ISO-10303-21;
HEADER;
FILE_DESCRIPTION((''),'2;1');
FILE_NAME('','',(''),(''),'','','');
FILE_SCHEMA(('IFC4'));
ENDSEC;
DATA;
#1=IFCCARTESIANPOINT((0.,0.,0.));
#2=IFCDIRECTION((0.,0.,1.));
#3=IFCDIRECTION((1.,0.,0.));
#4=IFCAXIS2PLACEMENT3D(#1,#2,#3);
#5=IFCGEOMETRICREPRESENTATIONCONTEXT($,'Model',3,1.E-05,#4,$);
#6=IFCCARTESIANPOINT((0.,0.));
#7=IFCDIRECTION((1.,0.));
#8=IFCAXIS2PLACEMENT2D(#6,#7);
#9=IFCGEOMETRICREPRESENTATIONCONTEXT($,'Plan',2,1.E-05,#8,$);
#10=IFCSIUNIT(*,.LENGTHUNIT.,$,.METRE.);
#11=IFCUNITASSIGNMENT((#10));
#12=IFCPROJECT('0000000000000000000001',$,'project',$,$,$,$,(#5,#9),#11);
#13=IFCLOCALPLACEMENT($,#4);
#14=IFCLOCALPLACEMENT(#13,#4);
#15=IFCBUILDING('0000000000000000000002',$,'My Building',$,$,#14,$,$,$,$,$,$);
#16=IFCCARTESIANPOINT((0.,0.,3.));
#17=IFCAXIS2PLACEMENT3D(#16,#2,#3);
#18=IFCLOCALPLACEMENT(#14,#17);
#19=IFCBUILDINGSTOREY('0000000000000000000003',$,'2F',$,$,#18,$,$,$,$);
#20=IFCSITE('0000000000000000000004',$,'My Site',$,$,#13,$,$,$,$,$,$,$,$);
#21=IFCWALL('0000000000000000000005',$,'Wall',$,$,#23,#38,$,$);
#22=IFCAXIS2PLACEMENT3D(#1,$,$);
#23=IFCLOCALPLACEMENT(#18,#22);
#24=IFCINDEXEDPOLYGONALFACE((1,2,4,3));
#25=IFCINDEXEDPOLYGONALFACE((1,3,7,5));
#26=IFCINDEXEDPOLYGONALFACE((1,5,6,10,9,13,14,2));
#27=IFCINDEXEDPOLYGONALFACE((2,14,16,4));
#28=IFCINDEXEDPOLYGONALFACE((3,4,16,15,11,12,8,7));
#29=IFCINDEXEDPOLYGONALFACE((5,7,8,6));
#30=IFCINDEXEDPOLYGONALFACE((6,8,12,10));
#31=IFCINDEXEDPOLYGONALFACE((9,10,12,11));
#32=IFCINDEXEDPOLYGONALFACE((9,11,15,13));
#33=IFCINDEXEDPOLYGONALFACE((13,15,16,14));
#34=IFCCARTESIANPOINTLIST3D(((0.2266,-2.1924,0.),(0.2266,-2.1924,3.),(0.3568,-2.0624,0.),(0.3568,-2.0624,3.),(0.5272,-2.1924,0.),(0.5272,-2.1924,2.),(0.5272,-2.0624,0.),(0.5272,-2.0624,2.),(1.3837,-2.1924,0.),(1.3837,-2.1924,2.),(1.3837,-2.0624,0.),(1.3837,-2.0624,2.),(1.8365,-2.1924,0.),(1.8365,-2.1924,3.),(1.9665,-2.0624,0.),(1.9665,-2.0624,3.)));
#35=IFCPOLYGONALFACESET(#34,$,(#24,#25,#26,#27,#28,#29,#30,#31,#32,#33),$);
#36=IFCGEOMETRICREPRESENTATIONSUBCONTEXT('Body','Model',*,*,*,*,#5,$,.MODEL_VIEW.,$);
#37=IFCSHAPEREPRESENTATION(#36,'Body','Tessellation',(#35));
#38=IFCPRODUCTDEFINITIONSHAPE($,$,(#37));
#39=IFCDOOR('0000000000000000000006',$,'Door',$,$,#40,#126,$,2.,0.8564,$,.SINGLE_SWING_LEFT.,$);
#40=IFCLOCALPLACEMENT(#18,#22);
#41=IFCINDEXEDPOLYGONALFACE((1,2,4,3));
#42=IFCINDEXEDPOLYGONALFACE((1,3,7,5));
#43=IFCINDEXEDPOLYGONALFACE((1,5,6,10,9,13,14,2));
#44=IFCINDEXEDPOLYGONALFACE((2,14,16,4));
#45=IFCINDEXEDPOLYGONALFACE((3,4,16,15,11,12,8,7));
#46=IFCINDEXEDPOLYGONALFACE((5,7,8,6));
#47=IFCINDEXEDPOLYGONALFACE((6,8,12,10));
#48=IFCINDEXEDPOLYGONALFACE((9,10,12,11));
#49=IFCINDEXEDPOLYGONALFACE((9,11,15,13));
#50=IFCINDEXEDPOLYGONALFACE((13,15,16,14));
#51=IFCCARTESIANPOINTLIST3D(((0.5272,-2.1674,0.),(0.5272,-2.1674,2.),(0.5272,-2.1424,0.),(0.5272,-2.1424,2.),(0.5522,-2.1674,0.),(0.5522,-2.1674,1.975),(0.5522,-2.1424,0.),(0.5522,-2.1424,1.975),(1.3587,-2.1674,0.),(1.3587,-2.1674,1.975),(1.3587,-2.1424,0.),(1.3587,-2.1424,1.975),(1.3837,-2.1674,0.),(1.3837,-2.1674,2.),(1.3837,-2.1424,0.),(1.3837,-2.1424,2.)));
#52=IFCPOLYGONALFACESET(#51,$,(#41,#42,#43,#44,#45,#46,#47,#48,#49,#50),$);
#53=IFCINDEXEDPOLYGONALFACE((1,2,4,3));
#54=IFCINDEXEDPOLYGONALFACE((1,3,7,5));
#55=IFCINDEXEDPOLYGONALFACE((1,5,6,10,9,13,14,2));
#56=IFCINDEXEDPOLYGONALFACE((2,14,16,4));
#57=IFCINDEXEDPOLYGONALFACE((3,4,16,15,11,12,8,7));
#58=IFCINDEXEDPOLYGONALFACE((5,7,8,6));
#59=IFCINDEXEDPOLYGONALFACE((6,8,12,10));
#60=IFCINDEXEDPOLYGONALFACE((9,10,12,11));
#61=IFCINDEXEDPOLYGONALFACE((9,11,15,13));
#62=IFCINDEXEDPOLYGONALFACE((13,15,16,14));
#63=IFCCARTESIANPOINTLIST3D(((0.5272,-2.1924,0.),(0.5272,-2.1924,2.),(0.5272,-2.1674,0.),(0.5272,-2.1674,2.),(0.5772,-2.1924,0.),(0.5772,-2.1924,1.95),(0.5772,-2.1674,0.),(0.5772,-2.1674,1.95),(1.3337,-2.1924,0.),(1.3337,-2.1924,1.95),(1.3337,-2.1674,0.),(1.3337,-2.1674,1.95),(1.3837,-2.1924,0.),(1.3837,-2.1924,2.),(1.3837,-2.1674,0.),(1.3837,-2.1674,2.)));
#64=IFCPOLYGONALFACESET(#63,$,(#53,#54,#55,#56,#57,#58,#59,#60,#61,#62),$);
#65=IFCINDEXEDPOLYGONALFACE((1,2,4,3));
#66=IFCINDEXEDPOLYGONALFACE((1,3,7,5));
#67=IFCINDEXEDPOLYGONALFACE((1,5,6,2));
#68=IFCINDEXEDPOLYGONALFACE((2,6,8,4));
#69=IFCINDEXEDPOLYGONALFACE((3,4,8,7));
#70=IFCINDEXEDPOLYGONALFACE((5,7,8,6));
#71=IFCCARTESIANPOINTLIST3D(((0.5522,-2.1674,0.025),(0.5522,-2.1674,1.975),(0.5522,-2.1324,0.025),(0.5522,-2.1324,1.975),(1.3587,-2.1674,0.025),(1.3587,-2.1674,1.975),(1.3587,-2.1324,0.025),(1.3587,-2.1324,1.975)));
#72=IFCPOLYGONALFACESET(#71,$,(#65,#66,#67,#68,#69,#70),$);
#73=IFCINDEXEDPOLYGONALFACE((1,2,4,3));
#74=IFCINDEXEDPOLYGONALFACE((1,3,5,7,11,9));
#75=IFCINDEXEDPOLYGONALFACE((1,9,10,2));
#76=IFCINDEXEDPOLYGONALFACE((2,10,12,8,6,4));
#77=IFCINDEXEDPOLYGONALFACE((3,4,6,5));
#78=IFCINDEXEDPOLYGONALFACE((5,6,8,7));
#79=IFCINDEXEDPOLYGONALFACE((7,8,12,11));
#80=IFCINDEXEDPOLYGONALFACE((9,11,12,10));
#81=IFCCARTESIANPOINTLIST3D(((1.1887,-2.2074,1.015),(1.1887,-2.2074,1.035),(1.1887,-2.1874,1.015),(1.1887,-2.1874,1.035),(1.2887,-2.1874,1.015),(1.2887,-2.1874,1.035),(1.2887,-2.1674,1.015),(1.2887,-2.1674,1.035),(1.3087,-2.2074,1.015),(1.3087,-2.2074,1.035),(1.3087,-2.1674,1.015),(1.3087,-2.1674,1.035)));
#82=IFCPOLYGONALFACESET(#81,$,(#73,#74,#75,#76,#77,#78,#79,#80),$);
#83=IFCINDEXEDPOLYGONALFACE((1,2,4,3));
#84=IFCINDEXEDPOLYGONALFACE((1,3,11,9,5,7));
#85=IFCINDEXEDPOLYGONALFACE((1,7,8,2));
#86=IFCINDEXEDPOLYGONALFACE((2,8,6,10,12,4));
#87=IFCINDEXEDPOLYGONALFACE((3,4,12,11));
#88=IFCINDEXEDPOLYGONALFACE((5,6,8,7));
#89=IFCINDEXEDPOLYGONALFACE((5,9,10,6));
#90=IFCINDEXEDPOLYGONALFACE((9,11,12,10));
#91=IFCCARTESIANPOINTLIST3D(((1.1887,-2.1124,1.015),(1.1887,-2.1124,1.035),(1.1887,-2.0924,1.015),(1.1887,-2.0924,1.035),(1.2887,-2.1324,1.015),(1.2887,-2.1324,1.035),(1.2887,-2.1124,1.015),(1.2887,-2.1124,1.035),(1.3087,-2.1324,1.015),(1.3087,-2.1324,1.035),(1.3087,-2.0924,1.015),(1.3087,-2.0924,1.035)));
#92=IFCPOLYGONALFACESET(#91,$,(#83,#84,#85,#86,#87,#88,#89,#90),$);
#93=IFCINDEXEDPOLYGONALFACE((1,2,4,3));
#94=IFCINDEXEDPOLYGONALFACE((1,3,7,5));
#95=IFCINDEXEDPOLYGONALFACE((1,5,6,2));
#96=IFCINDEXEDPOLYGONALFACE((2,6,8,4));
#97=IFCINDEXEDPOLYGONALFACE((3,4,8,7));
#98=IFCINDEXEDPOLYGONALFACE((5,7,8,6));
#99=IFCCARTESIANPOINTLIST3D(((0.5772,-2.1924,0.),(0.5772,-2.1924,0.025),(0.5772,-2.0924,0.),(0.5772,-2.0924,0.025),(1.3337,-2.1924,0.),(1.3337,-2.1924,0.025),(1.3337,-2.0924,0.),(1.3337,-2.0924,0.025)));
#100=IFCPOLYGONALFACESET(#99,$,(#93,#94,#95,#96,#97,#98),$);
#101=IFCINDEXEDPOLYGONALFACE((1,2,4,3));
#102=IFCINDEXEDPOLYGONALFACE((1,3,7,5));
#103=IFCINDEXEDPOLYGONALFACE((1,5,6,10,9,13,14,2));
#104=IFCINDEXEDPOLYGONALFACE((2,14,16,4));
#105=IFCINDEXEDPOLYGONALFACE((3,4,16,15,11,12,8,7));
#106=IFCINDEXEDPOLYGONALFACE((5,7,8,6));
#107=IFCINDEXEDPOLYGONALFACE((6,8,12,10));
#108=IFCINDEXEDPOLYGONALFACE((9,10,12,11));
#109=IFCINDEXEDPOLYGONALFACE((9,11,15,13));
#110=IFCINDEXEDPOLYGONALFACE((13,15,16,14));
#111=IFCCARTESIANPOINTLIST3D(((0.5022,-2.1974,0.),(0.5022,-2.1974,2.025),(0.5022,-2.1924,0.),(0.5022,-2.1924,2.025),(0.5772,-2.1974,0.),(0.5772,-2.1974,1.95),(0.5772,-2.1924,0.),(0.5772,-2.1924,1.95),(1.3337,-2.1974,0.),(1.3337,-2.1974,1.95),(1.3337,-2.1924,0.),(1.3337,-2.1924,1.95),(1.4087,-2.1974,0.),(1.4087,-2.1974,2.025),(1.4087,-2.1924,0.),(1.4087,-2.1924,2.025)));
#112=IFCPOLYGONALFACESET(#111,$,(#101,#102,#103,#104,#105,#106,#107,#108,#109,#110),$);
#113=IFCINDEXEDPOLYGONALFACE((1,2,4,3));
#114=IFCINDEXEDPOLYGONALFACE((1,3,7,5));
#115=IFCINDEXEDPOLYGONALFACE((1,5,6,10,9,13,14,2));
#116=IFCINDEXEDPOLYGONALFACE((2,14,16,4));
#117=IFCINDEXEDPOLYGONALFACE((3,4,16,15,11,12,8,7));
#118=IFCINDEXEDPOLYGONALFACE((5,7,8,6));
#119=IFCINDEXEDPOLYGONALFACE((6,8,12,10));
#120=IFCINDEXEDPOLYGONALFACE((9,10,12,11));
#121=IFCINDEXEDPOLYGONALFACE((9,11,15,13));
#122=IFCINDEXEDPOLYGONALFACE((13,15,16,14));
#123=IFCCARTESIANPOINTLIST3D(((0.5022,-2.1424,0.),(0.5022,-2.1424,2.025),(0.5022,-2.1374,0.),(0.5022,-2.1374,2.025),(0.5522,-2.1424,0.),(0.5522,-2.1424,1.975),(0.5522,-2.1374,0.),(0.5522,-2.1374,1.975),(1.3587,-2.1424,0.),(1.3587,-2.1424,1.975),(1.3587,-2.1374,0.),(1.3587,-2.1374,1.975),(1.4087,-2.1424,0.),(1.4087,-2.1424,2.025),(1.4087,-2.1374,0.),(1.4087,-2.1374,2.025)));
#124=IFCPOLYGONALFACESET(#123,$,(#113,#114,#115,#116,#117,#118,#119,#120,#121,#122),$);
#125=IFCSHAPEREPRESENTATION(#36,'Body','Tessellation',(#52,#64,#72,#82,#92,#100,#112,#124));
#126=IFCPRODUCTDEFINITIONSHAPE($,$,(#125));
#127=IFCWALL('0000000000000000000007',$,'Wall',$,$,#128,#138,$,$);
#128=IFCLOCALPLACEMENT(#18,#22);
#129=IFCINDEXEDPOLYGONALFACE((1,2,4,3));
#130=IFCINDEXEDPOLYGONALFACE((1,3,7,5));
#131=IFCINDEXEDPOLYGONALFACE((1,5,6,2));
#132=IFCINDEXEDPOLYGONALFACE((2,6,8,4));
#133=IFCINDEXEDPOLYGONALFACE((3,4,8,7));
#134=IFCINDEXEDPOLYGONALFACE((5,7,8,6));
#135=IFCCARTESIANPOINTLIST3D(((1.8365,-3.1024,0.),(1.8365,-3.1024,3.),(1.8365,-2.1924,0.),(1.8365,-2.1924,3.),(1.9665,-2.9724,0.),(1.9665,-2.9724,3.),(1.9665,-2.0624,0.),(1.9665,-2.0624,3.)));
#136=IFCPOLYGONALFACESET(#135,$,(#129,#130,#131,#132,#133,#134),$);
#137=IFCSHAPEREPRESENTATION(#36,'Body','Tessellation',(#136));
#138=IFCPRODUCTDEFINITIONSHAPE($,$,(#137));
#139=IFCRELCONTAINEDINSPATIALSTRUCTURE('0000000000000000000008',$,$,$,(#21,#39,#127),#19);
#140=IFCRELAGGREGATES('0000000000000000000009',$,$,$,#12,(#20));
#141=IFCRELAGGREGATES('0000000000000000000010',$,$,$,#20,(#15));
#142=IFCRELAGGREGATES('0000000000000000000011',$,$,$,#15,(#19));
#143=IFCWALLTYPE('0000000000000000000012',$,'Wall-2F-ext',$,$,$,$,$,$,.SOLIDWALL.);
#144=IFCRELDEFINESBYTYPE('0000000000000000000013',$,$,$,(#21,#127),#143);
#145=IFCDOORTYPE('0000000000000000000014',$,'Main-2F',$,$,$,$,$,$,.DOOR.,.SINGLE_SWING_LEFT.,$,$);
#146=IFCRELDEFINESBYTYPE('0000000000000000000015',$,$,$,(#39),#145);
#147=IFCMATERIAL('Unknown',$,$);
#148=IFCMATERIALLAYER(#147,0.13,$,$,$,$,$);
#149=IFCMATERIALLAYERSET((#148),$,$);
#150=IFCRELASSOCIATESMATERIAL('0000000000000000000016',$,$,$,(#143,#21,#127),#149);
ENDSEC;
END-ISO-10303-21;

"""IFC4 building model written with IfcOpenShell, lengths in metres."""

from ifc_helpers import new_model, entity, si_unit, frame, origin_with_axes, origin_2d_with_axis, place, context, subcontext, project, spatial, line, indexed_curve, outline, extrude, shape, source, transform, mapped, material, layer, layer_set, layer_usage, type_object, type_shapes, element, fill, save


model = new_model("IFC4")

# Units and contexts
model_context = context("Model", 3, precision=1e-05, world=origin_with_axes())
plan_context = context("Plan", 2, precision=1e-05, world=origin_2d_with_axis())
body_context_1 = subcontext(model_context, "Body", "Model", "MODEL_VIEW")
body_context_2 = subcontext(plan_context, "Body", "Plan", "PLAN_VIEW")
ifc_project = project(units=[si_unit("LENGTHUNIT", "METRE")], contexts=[model_context, plan_context])

# Site, building, storey
site_placement = place(None, origin_with_axes())
site = spatial("IfcSite", under=ifc_project, at=site_placement, Name="My Site")
building_placement = place(site_placement, origin_with_axes())
building = spatial("IfcBuilding", under=site, at=building_placement, Name="My Building")
storey_placement = place(building_placement, frame((0.0, 0.0, 3.0), z_axis=(0.0, 0.0, 1.0), x_axis=(1.0, 0.0, 0.0)))
storey = spatial("IfcBuildingStorey", under=building, at=storey_placement, Name="2F")

# Shared definitions
ifc_material = material(Name="Unknown")

# Shared definitions
ifc_layer_1 = layer(ifc_material, 0.13)
ifc_layer_set_1 = layer_set([ifc_layer_1])
wall_type_1 = type_object("IfcWallType", Name="Wall-2F-ext", PredefinedType="SOLIDWALL", material=ifc_layer_set_1)

# Wall, opening, door
ifc_layer_usage_1 = layer_usage(ifc_layer_set_1, "AXIS2", "POSITIVE", 0.0)
wall_1_placement = place(storey_placement, frame((0.2266, -2.1924, 0.0), z_axis=(0.0, 0.0, 1.0), x_axis=(1.0, 0.0, 0.0)))
wall_1 = element("IfcWall", 1, at=wall_1_placement, inside=storey, type_object=wall_type_1, material=ifc_layer_usage_1, Name="Wall", context=body_context_1, shape_type="SweptSolid", body=[
    extrude(outline(indexed_curve([(0.0, 0.0), (0.1302, 0.13), (1.7399, 0.13), (1.6099, 0.0)], segments=[line(1, 2, 3, 4, 1)])), origin_with_axes(), (0.0, 0.0, 1.0), 3.0),
])
shared_shape_1 = source(origin_with_axes(), body_context_1, "Body", "SweptSolid", [
    extrude(outline(indexed_curve([(0.0, 0.0), (0.8564, 0.0), (0.8564, 2.0), (0.0, 2.0)], segments=[line(1, 2, 3, 4, 1)])), frame((0.0, -0.6, 0.0), z_axis=(0.0, -1.0, 0.0), x_axis=(1.0, 0.0, 0.0)), (0.0, 0.0, -1.0), 1.2),
])
opening_1_placement = place(wall_1_placement, frame((0.3006, 0.0, 0.0), z_axis=(0.0, 0.0, 1.0), x_axis=(1.0, 0.0, 0.0)))
opening_1 = element("IfcOpeningElement", 2, at=opening_1_placement, cuts=wall_1, PredefinedType="OPENING", context=body_context_1, shape_type="MappedRepresentation", body=[
    mapped(shared_shape_1, transform((0.0, 0.0, 0.0), x_axis=(1.0, 0.0, 0.0), y_axis=(0.0, 1.0, 0.0), z_axis=(0.0, 0.0, 1.0), scale=1.0)),
])
door_type_1 = type_object("IfcDoorType", Name="Main-2F", OperationType="SINGLE_SWING_LEFT", PredefinedType="DOOR")
shared_shape_2 = source(origin_with_axes(), body_context_1, "Body", "SweptSolid", [
    extrude(outline(indexed_curve([(0.0, 0.0), (0.0, 2.0), (0.8564, 2.0), (0.8564, 0.0), (0.8314, 0.0), (0.8314, 1.975), (0.025, 1.975), (0.025, 0.0)], segments=[line(1, 2, 3, 4, 5, 6, 7, 8, 1)])), frame((0.0, 0.025, 0.0), z_axis=(0.0, -1.0, 0.0), x_axis=(1.0, 0.0, 0.0)), (0.0, 0.0, -1.0), 0.025),
    extrude(outline(indexed_curve([(0.0, 0.0), (0.0, 2.0), (0.8564, 2.0), (0.8564, 0.0), (0.8064, 0.0), (0.8064, 1.95), (0.05, 1.95), (0.05, 0.0)], segments=[line(1, 2, 3, 4, 5, 6, 7, 8, 1)])), frame((0.0, 0.0, 0.0), z_axis=(0.0, -1.0, 0.0), x_axis=(1.0, 0.0, 0.0)), (0.0, 0.0, -1.0), 0.025),
    extrude(outline(indexed_curve([(0.0, 0.0), (0.8064, 0.0), (0.8064, 0.035), (0.0, 0.035)], segments=[line(1, 2, 3, 4, 1)])), frame((0.025, 0.025, 0.025), z_axis=(0.0, 0.0, 1.0), x_axis=(1.0, 0.0, 0.0)), (0.0, 0.0, 1.0), 1.95),
    extrude(outline(indexed_curve([(0.0, 0.0), (0.0, -0.04), (-0.12, -0.04), (-0.12, -0.02), (-0.02, -0.02), (-0.02, 0.0)], segments=[line(1, 2, 3, 4, 5, 6, 1)])), frame((0.7814, 0.025, 1.015), z_axis=(0.0, 0.0, 1.0), x_axis=(1.0, 0.0, 0.0)), (0.0, 0.0, 1.0), 0.02),
    extrude(outline(indexed_curve([(0.0, 0.0), (0.0, 0.04), (-0.12, 0.04), (-0.12, 0.02), (-0.02, 0.02), (-0.02, 0.0)], segments=[line(1, 2, 3, 4, 5, 6, 1)])), frame((0.7814, 0.06, 1.015), z_axis=(0.0, 0.0, 1.0), x_axis=(1.0, 0.0, 0.0)), (0.0, 0.0, 1.0), 0.02),
    extrude(outline(indexed_curve([(0.0, 0.0), (0.7564, 0.0), (0.7564, 0.1), (0.0, 0.1)], segments=[line(1, 2, 3, 4, 1)])), frame((0.05, 0.0, 0.0), z_axis=(0.0, 0.0, 1.0), x_axis=(1.0, 0.0, 0.0)), (0.0, 0.0, 1.0), 0.025),
    extrude(outline(indexed_curve([(0.0, 0.0), (0.0, 2.025), (0.9064, 2.025), (0.9064, 0.0), (0.8314, 0.0), (0.8314, 1.95), (0.075, 1.95), (0.075, 0.0)], segments=[line(1, 2, 3, 4, 5, 6, 7, 8, 1)])), frame((-0.025, -0.005, 0.0), z_axis=(0.0, -1.0, 0.0), x_axis=(1.0, 0.0, 0.0)), (0.0, 0.0, -1.0), 0.005),
    extrude(outline(indexed_curve([(0.0, 0.0), (0.0, 2.025), (0.9064, 2.025), (0.9064, 0.0), (0.8564, 0.0), (0.8564, 1.975), (0.05, 1.975), (0.05, 0.0)], segments=[line(1, 2, 3, 4, 5, 6, 7, 8, 1)])), frame((-0.025, 0.05, 0.0), z_axis=(0.0, -1.0, 0.0), x_axis=(1.0, 0.0, 0.0)), (0.0, 0.0, -1.0), 0.005),
])
shared_shape_3 = source(origin_with_axes(), body_context_2, "Body", "Curve2D", [
    entity("IfcIndexedPolyCurve", entity("IfcCartesianPointList2D", [[0.0, 0.0], [0.0, 0.05], [0.025, 0.05], [0.025, 0.025], [0.05, 0.025], [0.05, 0.0]]), [entity("IfcLineIndex", [1, 2, 3, 4, 5, 6, 1])]),
    entity("IfcIndexedPolyCurve", entity("IfcCartesianPointList2D", [[0.8564, 0.0], [0.8564, 0.05], [0.8314, 0.05], [0.8314, 0.025], [0.8064, 0.025], [0.8064, 0.0]]), [entity("IfcLineIndex", [1, 2, 3, 4, 5, 6, 1])]),
    entity("IfcTrimmedCurve", entity("IfcEllipse", entity("IfcAxis2Placement2D", entity("IfcCartesianPoint", [0.06, 0.05]), entity("IfcDirection", [1.0, 0.0])), 0.7714, 0.8064), [entity("IfcCartesianPoint", [0.8314, 0.05])], [entity("IfcCartesianPoint", [0.06, 0.8564])], True, "CARTESIAN"),
    entity("IfcIndexedPolyCurve", entity("IfcCartesianPointList2D", [[0.025, 0.05], [0.06, 0.05], [0.06, 0.8564], [0.025, 0.8564]]), [entity("IfcLineIndex", [1, 2, 3, 4, 1])]),
])
type_shapes(door_type_1, [shared_shape_2, shared_shape_3])
door_1_placement = place(opening_1_placement, origin_with_axes())
door_1 = element("IfcDoor", 3, at=door_1_placement, inside=storey, type_object=door_type_1, Name="Door", OperationType="SINGLE_SWING_LEFT", OverallHeight=2.0, OverallWidth=0.8564, shapes=[
    shape(body_context_1, "Body", "MappedRepresentation", [mapped(shared_shape_2, transform((0.0, 0.0, 0.0), x_axis=(1.0, 0.0, 0.0), y_axis=(0.0, 1.0, 0.0), z_axis=(0.0, 0.0, 1.0), scale=1.0))]),
    shape(body_context_2, "Body", "MappedRepresentation", [mapped(shared_shape_3, transform((0.0, 0.0, 0.0), x_axis=(1.0, 0.0, 0.0), y_axis=(0.0, 1.0, 0.0), z_axis=(0.0, 0.0, 1.0), scale=1.0))]),
])
fill(opening_1, door_1)

# Wall
ifc_layer_usage_2 = layer_usage(ifc_layer_set_1, "AXIS2", "POSITIVE", 0.0)
wall_2_placement = place(storey_placement, frame((1.8365, -2.1924, 0.0), z_axis=(0.0, 0.0, 1.0), x_axis=(0.0, -1.0, 0.0)))
element("IfcWall", 4, at=wall_2_placement, inside=storey, type_object=wall_type_1, material=ifc_layer_usage_2, Name="Wall", context=body_context_1, shape_type="SweptSolid", body=[
    extrude(outline(indexed_curve([(0.0, 0.0), (-0.13, 0.13), (0.78, 0.13), (0.91, 0.0)], segments=[line(1, 2, 3, 4, 1)])), origin_with_axes(), (0.0, 0.0, 1.0), 3.0),
])

save(model, "model.ifc")
